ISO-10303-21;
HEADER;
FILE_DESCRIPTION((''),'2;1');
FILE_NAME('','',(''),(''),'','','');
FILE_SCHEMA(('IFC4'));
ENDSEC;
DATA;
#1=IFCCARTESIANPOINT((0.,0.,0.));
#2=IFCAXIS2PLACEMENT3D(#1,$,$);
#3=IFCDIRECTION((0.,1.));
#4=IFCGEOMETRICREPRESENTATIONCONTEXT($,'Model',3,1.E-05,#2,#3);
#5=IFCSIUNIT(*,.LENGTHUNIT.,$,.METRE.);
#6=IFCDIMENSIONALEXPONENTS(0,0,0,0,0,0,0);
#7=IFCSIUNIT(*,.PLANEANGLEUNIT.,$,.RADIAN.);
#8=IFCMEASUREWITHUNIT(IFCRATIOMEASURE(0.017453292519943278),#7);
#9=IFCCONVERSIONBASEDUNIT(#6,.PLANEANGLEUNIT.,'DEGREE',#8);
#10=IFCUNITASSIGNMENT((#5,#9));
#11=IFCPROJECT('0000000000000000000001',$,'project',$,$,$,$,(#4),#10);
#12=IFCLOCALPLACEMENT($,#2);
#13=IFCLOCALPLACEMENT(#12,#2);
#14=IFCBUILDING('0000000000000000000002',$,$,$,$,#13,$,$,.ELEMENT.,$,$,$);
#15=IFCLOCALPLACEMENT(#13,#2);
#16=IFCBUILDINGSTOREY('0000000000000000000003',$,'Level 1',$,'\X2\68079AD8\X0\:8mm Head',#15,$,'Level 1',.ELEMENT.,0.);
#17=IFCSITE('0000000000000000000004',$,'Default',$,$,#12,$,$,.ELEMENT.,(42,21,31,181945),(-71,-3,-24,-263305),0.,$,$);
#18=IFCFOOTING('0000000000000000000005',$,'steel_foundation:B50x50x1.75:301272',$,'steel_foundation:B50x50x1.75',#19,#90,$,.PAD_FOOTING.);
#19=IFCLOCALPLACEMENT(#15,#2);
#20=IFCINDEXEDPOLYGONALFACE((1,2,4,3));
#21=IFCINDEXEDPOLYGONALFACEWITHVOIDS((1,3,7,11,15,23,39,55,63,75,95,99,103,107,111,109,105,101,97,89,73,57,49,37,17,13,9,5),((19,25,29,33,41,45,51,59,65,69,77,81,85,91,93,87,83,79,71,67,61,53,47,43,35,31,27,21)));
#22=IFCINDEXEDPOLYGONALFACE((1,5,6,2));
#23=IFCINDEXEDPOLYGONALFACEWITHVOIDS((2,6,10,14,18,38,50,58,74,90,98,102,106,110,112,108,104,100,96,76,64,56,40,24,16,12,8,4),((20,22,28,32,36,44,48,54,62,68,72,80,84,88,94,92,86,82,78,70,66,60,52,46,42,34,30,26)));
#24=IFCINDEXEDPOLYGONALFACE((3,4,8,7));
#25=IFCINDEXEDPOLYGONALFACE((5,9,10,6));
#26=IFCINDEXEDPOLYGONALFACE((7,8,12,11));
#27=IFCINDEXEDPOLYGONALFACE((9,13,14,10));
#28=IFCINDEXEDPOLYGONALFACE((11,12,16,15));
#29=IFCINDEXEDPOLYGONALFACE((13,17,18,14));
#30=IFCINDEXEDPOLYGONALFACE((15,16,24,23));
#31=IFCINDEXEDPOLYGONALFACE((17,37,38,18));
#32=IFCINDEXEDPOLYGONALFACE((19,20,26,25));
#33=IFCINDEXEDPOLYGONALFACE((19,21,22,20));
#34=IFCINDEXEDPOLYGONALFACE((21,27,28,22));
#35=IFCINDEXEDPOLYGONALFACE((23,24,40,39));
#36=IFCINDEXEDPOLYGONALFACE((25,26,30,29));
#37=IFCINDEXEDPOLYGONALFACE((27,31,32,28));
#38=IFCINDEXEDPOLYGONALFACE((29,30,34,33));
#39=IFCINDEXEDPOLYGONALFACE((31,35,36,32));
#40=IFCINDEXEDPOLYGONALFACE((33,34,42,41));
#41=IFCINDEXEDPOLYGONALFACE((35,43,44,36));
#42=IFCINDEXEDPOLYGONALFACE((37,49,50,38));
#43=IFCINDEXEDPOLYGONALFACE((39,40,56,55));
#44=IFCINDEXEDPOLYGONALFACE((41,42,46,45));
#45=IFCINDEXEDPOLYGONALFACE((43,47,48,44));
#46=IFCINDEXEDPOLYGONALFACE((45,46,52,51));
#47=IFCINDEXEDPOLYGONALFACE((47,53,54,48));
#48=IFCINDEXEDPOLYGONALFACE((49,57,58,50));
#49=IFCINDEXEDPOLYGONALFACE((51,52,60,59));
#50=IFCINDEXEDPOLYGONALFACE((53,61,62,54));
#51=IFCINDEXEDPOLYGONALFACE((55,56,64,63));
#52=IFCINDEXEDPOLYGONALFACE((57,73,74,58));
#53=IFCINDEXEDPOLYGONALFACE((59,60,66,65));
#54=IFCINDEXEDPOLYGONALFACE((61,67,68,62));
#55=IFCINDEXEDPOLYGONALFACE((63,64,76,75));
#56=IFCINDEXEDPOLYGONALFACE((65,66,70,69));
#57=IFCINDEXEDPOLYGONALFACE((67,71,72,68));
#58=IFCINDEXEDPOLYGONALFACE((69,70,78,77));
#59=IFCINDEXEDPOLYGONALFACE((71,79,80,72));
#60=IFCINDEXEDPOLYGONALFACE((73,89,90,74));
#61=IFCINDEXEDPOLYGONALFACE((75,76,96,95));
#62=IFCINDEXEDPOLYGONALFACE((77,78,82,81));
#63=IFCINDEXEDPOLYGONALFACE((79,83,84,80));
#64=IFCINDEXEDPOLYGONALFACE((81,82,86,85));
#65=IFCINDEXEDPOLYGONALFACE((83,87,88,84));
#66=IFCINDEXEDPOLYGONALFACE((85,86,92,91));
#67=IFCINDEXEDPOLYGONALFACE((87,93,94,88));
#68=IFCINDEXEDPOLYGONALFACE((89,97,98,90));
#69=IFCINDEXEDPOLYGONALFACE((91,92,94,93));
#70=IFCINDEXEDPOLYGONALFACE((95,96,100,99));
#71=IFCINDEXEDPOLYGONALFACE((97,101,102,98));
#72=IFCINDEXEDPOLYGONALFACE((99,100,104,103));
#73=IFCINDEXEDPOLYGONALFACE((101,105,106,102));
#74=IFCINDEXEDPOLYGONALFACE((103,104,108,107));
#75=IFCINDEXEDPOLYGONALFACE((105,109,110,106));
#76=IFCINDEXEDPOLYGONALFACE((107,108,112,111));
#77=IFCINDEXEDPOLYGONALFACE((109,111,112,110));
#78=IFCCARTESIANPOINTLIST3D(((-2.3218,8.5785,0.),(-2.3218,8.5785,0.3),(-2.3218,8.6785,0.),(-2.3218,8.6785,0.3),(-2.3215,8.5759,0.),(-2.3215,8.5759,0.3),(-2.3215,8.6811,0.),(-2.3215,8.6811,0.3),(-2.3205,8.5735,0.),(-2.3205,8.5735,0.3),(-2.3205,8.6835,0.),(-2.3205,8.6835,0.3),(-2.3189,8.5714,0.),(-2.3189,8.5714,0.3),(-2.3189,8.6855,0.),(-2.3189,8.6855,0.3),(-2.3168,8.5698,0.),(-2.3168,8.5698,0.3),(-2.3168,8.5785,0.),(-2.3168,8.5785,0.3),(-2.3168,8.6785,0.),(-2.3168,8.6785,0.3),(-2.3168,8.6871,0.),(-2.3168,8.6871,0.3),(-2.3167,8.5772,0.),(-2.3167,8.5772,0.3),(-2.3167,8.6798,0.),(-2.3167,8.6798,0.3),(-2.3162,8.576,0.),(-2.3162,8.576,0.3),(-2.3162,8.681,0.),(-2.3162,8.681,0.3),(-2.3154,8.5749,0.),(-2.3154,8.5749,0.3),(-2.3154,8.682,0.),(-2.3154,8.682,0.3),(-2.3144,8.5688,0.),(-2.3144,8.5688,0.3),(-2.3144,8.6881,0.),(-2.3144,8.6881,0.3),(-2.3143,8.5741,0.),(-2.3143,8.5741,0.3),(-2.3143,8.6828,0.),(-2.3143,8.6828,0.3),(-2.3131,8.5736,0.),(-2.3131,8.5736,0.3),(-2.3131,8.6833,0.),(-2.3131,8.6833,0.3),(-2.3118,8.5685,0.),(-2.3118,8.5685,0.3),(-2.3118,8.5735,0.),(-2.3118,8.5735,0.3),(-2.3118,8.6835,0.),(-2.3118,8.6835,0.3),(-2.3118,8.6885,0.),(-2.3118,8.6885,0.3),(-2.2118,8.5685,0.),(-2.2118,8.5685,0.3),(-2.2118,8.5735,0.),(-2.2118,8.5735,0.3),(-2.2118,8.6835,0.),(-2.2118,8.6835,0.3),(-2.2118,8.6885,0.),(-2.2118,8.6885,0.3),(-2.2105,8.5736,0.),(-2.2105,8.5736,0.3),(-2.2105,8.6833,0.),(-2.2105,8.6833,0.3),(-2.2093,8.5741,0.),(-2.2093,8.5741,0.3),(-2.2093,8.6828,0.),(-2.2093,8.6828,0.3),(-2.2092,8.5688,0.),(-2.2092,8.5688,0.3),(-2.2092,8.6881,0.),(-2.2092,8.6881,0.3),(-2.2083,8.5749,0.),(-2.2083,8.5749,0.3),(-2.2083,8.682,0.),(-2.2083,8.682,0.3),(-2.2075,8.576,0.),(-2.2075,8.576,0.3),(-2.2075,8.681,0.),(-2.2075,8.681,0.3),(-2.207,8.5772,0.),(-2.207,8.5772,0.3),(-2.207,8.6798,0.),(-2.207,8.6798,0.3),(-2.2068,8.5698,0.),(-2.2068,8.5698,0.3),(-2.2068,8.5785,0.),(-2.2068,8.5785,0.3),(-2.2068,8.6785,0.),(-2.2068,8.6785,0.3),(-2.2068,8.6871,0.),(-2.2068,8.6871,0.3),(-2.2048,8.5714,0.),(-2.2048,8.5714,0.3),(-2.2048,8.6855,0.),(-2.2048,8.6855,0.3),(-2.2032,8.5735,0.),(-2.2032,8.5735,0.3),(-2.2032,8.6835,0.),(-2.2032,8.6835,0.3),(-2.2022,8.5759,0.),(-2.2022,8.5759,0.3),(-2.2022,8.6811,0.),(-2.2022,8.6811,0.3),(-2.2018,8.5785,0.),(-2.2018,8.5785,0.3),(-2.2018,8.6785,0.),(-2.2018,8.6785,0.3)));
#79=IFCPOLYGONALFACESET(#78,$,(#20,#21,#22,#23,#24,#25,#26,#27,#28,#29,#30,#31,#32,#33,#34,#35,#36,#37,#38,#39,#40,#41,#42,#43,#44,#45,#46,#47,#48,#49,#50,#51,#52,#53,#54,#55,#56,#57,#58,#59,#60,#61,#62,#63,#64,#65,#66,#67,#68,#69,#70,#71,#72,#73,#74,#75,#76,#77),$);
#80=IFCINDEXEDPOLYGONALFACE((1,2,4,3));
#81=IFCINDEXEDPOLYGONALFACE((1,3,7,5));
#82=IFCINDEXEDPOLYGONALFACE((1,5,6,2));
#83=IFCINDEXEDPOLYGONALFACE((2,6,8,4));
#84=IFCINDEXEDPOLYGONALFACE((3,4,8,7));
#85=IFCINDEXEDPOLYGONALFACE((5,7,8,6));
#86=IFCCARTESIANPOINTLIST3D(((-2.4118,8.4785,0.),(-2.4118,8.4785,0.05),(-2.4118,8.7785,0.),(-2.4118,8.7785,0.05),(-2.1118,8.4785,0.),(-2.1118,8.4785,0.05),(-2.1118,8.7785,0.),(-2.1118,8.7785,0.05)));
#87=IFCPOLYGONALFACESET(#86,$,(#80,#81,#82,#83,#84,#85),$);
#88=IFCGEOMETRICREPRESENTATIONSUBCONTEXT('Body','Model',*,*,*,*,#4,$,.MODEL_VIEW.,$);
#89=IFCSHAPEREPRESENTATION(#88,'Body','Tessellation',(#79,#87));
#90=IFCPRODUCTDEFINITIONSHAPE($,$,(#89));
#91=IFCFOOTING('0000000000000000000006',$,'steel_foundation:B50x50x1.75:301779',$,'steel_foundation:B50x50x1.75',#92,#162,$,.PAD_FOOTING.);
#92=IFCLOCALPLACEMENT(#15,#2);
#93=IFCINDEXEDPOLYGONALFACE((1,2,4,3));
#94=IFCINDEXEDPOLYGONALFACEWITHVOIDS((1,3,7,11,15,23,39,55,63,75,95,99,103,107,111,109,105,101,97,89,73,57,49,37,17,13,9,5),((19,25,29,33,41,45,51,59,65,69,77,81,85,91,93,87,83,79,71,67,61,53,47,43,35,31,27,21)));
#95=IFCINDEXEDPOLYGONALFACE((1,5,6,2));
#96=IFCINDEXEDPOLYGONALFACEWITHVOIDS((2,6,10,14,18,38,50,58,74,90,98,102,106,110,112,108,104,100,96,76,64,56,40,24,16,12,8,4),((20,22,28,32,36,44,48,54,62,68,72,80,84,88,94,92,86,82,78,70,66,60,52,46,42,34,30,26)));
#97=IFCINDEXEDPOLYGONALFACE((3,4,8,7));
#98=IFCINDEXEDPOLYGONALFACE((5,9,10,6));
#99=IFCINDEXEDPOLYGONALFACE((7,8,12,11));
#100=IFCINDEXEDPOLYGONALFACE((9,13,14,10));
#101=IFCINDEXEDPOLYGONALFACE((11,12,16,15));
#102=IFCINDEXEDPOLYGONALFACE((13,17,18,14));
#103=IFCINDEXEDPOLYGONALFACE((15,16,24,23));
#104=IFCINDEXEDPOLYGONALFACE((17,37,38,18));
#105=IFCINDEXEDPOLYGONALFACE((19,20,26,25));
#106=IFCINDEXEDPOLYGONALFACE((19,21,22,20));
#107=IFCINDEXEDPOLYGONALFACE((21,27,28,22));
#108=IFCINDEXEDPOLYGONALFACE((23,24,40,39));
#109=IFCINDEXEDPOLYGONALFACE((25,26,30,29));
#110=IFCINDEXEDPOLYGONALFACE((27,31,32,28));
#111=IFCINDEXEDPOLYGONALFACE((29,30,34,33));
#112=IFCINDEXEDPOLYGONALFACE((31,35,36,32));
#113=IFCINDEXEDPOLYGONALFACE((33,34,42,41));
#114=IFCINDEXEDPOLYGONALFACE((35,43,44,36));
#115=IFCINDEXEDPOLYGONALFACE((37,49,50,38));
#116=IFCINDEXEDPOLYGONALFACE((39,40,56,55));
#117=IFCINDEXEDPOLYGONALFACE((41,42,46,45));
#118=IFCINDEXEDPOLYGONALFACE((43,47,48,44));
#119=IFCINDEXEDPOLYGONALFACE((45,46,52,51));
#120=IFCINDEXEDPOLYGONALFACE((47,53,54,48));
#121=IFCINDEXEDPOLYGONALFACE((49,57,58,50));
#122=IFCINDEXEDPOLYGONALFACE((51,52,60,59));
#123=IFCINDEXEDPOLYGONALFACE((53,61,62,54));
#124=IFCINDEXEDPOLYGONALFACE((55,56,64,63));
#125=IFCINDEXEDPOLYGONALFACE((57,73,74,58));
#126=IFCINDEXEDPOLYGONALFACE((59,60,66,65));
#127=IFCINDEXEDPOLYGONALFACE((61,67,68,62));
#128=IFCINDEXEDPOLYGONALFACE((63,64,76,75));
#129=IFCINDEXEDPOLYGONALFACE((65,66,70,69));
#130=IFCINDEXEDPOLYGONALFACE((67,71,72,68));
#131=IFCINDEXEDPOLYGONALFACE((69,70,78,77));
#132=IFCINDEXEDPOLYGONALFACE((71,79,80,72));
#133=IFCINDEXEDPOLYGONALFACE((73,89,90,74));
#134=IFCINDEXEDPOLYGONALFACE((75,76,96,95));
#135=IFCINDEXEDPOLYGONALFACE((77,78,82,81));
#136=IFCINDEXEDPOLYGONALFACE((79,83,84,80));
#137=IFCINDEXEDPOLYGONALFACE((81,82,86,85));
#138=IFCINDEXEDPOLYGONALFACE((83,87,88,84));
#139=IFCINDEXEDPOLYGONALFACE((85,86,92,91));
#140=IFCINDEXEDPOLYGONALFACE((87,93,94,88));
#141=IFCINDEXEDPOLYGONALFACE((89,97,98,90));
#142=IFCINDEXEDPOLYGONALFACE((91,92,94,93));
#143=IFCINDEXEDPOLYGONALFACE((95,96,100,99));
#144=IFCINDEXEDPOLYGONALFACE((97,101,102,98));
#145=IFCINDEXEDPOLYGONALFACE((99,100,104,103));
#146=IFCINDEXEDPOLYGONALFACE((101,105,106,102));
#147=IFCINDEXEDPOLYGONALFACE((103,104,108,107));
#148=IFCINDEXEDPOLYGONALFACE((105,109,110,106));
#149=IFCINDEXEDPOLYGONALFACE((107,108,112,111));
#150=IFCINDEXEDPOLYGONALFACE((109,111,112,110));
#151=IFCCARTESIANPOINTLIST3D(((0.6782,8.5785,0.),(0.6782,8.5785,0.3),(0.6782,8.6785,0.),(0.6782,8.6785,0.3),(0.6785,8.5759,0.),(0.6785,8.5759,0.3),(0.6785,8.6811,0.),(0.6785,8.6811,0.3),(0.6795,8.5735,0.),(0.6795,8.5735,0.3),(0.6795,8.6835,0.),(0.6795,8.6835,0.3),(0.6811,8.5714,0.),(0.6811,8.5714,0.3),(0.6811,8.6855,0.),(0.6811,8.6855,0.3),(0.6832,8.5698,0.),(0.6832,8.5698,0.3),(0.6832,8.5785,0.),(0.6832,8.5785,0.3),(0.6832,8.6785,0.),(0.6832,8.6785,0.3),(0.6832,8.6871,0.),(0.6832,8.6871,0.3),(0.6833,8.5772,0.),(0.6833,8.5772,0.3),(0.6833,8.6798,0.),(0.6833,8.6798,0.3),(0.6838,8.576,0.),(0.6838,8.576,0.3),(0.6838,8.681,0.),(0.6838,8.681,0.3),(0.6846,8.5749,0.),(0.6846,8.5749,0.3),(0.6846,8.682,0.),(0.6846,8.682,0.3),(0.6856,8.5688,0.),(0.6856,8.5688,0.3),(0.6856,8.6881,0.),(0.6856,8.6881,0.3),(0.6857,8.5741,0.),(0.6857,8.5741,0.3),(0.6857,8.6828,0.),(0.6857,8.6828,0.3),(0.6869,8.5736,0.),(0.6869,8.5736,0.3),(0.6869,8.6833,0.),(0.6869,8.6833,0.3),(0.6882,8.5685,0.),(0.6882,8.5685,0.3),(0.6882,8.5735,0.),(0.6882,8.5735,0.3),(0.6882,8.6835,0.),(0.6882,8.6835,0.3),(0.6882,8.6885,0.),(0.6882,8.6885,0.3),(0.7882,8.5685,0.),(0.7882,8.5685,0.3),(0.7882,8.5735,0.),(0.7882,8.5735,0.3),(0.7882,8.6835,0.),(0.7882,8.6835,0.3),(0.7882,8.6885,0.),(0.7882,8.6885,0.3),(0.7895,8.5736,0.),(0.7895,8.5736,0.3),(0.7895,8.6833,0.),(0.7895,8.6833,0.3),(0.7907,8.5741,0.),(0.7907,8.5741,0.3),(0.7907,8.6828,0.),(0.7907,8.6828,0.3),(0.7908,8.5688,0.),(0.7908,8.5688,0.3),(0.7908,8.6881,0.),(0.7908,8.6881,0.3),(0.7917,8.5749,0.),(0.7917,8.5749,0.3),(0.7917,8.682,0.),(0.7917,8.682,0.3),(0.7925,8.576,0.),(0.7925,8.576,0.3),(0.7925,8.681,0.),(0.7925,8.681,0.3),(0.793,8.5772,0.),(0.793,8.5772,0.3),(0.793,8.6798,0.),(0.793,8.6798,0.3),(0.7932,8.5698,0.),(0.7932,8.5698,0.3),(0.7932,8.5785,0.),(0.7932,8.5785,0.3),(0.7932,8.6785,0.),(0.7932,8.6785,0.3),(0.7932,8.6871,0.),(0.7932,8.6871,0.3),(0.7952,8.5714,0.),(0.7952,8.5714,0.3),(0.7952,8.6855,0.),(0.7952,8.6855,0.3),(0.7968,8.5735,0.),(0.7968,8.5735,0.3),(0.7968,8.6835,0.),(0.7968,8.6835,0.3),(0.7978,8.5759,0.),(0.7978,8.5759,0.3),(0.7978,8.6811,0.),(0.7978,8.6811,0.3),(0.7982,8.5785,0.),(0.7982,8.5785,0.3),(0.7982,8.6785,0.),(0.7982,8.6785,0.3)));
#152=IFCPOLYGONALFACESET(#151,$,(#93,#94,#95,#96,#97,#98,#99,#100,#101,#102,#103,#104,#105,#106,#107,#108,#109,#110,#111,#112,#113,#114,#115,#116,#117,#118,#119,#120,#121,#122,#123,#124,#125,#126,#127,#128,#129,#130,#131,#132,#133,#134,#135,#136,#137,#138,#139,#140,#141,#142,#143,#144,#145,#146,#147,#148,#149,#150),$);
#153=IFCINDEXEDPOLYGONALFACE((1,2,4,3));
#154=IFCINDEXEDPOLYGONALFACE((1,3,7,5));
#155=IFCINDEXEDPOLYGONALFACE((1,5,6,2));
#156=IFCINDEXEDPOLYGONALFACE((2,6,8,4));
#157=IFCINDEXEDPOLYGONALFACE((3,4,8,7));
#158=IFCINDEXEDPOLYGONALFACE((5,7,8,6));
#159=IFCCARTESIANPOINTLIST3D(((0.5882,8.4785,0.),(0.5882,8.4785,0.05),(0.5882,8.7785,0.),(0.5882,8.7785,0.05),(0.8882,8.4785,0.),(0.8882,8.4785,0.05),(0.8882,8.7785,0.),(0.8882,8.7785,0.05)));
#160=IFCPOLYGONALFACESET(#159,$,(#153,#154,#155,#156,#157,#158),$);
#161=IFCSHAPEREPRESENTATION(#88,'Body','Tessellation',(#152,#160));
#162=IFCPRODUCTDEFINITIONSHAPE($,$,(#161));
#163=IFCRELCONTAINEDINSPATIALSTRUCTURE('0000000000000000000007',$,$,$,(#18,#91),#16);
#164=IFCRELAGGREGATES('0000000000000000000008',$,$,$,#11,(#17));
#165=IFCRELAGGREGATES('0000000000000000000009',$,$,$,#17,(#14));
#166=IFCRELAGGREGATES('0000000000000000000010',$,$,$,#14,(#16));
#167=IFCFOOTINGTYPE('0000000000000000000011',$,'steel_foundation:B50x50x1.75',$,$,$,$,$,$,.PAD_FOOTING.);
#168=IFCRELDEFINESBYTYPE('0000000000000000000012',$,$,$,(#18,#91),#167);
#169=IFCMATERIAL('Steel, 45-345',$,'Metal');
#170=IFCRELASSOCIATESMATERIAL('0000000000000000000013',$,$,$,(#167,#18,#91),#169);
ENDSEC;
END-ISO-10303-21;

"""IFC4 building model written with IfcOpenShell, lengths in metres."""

from ifc_helpers import new_model, entity, si_unit, converted_unit, direction, frame, frame_2d, origin, place, context, subcontext, project, spatial, polyline, circle_curve, parameter, trimmed, segment, composite_curve, rectangle, outline, extrude, source, transform, mapped, material, type_object, type_shapes, element, save


model = new_model("IFC4")

# Units and contexts
model_context = context("Model", 3, precision=1e-05, world=origin(), true_north=direction((0.0, 1.0)))
body_context = subcontext(model_context, "Body", "Model", "MODEL_VIEW")
ifc_project = project(units=[si_unit("LENGTHUNIT", "METRE"), converted_unit("PLANEANGLEUNIT", "DEGREE", entity("IfcRatioMeasure", 0.017453292519943278), si_unit("PLANEANGLEUNIT", "RADIAN"), dimensions=[0, 0, 0, 0, 0, 0, 0])], contexts=[model_context])

# Site, building, storey
site_placement = place(None, origin())
site = spatial("IfcSite", under=ifc_project, at=site_placement, Name="Default", CompositionType="ELEMENT", RefLatitude=(42, 21, 31, 181945), RefLongitude=(-71, -3, -24, -263305), RefElevation=0.0)
building_placement = place(site_placement, origin())
building = spatial("IfcBuilding", under=site, at=building_placement, CompositionType="ELEMENT")
storey_placement = place(building_placement, origin())
storey = spatial("IfcBuildingStorey", under=building, at=storey_placement, Name="Level 1", ObjectType="标高:8mm Head", LongName="Level 1", CompositionType="ELEMENT", Elevation=0.0)

# Footings
ifc_material_1 = material(Name="Steel, 45-345", Category="Metal")
footing_type = type_object("IfcFootingType", Name="steel_foundation:B50x50x1.75", PredefinedType="PAD_FOOTING", material=ifc_material_1)
shared_shape_1 = source(origin(), body_context, "Body", "SweptSolid", [
    extrude(outline(composite_curve([segment(polyline([(-0.05, -0.06), (0.05, -0.06)]), True, "CONTINUOUS"), segment(trimmed(circle_curve(frame_2d((0.05, -0.05), x_axis=(-1.0, 0.0)), 0.01), [parameter(90.0)], [parameter(180.0)], True, "PARAMETER"), True, "CONTINUOUS"), segment(polyline([(0.06, -0.05), (0.06, 0.05)]), True, "CONTINUOUS"), segment(trimmed(circle_curve(frame_2d((0.05, 0.05), x_axis=(-1.0, 0.0)), 0.01), [parameter(180.0)], [parameter(270.0)], True, "PARAMETER"), True, "CONTINUOUS"), segment(polyline([(0.05, 0.06), (-0.05, 0.06)]), True, "CONTINUOUS"), segment(trimmed(circle_curve(frame_2d((-0.05, 0.05), x_axis=(-1.0, 0.0)), 0.01), [parameter(270.0)], [parameter(360.0)], True, "PARAMETER"), True, "CONTINUOUS"), segment(polyline([(-0.06, 0.05), (-0.06, -0.05)]), True, "CONTINUOUS"), segment(trimmed(circle_curve(frame_2d((-0.05, -0.05), x_axis=(-1.0, 0.0)), 0.01), [parameter(360.0)], [parameter(90.0)], True, "PARAMETER"), True, "CONTINUOUS")], self_intersect=False), holes=[composite_curve([segment(trimmed(circle_curve(frame_2d((-0.05, -0.05), x_axis=(-1.0, 0.0)), 0.005), [parameter(0.0)], [parameter(90.0)], True, "PARAMETER"), False, "CONTINUOUS"), segment(polyline([(-0.055, -0.05), (-0.055, 0.05)]), True, "CONTINUOUS"), segment(trimmed(circle_curve(frame_2d((-0.05, 0.05), x_axis=(-1.0, 0.0)), 0.005), [parameter(270.0)], [parameter(360.0)], True, "PARAMETER"), False, "CONTINUOUS"), segment(polyline([(-0.05, 0.055), (0.05, 0.055)]), True, "CONTINUOUS"), segment(trimmed(circle_curve(frame_2d((0.05, 0.05), x_axis=(-1.0, 0.0)), 0.005), [parameter(180.0)], [parameter(270.0)], True, "PARAMETER"), False, "CONTINUOUS"), segment(polyline([(0.055, 0.05), (0.055, -0.05)]), True, "CONTINUOUS"), segment(trimmed(circle_curve(frame_2d((0.05, -0.05), x_axis=(-1.0, 0.0)), 0.005), [parameter(90.0)], [parameter(180.0)], True, "PARAMETER"), False, "CONTINUOUS"), segment(polyline([(0.05, -0.055), (-0.05, -0.055)]), True, "CONTINUOUS")], self_intersect=False)]), frame((0.0, 0.0, 0.0), z_axis=(0.0, 0.0, 1.0), x_axis=(-1.0, 0.0, 0.0)), (0.0, 0.0, 1.0), 0.3),
    extrude(rectangle(XDim=0.3, YDim=0.3, at=frame_2d((0.0, 0.0), x_axis=(1.0, 0.0))), frame((0.0, 0.0, 0.0), z_axis=(0.0, 0.0, 1.0), x_axis=(-1.0, 0.0, 0.0)), (0.0, 0.0, 1.0), 0.05),
])
type_shapes(footing_type, [shared_shape_1])
for number, where, name in (
    (1, (-2.2618, 8.6285, 0.0), "steel_foundation:B50x50x1.75:301272"),
    (2, (0.7382, 8.6285, 0.0), "steel_foundation:B50x50x1.75:301779"),
):
    element("IfcFooting", number, at=place(storey_placement, frame(where)), inside=storey, type_object=footing_type, material=ifc_material_1, Name=name, ObjectType="steel_foundation:B50x50x1.75", PredefinedType="PAD_FOOTING", context=body_context, shape_type="MappedRepresentation", body=[
        mapped(shared_shape_1, transform((0.0, 0.0, 0.0), scale=1.0)),
    ])

save(model, "model.ifc")
